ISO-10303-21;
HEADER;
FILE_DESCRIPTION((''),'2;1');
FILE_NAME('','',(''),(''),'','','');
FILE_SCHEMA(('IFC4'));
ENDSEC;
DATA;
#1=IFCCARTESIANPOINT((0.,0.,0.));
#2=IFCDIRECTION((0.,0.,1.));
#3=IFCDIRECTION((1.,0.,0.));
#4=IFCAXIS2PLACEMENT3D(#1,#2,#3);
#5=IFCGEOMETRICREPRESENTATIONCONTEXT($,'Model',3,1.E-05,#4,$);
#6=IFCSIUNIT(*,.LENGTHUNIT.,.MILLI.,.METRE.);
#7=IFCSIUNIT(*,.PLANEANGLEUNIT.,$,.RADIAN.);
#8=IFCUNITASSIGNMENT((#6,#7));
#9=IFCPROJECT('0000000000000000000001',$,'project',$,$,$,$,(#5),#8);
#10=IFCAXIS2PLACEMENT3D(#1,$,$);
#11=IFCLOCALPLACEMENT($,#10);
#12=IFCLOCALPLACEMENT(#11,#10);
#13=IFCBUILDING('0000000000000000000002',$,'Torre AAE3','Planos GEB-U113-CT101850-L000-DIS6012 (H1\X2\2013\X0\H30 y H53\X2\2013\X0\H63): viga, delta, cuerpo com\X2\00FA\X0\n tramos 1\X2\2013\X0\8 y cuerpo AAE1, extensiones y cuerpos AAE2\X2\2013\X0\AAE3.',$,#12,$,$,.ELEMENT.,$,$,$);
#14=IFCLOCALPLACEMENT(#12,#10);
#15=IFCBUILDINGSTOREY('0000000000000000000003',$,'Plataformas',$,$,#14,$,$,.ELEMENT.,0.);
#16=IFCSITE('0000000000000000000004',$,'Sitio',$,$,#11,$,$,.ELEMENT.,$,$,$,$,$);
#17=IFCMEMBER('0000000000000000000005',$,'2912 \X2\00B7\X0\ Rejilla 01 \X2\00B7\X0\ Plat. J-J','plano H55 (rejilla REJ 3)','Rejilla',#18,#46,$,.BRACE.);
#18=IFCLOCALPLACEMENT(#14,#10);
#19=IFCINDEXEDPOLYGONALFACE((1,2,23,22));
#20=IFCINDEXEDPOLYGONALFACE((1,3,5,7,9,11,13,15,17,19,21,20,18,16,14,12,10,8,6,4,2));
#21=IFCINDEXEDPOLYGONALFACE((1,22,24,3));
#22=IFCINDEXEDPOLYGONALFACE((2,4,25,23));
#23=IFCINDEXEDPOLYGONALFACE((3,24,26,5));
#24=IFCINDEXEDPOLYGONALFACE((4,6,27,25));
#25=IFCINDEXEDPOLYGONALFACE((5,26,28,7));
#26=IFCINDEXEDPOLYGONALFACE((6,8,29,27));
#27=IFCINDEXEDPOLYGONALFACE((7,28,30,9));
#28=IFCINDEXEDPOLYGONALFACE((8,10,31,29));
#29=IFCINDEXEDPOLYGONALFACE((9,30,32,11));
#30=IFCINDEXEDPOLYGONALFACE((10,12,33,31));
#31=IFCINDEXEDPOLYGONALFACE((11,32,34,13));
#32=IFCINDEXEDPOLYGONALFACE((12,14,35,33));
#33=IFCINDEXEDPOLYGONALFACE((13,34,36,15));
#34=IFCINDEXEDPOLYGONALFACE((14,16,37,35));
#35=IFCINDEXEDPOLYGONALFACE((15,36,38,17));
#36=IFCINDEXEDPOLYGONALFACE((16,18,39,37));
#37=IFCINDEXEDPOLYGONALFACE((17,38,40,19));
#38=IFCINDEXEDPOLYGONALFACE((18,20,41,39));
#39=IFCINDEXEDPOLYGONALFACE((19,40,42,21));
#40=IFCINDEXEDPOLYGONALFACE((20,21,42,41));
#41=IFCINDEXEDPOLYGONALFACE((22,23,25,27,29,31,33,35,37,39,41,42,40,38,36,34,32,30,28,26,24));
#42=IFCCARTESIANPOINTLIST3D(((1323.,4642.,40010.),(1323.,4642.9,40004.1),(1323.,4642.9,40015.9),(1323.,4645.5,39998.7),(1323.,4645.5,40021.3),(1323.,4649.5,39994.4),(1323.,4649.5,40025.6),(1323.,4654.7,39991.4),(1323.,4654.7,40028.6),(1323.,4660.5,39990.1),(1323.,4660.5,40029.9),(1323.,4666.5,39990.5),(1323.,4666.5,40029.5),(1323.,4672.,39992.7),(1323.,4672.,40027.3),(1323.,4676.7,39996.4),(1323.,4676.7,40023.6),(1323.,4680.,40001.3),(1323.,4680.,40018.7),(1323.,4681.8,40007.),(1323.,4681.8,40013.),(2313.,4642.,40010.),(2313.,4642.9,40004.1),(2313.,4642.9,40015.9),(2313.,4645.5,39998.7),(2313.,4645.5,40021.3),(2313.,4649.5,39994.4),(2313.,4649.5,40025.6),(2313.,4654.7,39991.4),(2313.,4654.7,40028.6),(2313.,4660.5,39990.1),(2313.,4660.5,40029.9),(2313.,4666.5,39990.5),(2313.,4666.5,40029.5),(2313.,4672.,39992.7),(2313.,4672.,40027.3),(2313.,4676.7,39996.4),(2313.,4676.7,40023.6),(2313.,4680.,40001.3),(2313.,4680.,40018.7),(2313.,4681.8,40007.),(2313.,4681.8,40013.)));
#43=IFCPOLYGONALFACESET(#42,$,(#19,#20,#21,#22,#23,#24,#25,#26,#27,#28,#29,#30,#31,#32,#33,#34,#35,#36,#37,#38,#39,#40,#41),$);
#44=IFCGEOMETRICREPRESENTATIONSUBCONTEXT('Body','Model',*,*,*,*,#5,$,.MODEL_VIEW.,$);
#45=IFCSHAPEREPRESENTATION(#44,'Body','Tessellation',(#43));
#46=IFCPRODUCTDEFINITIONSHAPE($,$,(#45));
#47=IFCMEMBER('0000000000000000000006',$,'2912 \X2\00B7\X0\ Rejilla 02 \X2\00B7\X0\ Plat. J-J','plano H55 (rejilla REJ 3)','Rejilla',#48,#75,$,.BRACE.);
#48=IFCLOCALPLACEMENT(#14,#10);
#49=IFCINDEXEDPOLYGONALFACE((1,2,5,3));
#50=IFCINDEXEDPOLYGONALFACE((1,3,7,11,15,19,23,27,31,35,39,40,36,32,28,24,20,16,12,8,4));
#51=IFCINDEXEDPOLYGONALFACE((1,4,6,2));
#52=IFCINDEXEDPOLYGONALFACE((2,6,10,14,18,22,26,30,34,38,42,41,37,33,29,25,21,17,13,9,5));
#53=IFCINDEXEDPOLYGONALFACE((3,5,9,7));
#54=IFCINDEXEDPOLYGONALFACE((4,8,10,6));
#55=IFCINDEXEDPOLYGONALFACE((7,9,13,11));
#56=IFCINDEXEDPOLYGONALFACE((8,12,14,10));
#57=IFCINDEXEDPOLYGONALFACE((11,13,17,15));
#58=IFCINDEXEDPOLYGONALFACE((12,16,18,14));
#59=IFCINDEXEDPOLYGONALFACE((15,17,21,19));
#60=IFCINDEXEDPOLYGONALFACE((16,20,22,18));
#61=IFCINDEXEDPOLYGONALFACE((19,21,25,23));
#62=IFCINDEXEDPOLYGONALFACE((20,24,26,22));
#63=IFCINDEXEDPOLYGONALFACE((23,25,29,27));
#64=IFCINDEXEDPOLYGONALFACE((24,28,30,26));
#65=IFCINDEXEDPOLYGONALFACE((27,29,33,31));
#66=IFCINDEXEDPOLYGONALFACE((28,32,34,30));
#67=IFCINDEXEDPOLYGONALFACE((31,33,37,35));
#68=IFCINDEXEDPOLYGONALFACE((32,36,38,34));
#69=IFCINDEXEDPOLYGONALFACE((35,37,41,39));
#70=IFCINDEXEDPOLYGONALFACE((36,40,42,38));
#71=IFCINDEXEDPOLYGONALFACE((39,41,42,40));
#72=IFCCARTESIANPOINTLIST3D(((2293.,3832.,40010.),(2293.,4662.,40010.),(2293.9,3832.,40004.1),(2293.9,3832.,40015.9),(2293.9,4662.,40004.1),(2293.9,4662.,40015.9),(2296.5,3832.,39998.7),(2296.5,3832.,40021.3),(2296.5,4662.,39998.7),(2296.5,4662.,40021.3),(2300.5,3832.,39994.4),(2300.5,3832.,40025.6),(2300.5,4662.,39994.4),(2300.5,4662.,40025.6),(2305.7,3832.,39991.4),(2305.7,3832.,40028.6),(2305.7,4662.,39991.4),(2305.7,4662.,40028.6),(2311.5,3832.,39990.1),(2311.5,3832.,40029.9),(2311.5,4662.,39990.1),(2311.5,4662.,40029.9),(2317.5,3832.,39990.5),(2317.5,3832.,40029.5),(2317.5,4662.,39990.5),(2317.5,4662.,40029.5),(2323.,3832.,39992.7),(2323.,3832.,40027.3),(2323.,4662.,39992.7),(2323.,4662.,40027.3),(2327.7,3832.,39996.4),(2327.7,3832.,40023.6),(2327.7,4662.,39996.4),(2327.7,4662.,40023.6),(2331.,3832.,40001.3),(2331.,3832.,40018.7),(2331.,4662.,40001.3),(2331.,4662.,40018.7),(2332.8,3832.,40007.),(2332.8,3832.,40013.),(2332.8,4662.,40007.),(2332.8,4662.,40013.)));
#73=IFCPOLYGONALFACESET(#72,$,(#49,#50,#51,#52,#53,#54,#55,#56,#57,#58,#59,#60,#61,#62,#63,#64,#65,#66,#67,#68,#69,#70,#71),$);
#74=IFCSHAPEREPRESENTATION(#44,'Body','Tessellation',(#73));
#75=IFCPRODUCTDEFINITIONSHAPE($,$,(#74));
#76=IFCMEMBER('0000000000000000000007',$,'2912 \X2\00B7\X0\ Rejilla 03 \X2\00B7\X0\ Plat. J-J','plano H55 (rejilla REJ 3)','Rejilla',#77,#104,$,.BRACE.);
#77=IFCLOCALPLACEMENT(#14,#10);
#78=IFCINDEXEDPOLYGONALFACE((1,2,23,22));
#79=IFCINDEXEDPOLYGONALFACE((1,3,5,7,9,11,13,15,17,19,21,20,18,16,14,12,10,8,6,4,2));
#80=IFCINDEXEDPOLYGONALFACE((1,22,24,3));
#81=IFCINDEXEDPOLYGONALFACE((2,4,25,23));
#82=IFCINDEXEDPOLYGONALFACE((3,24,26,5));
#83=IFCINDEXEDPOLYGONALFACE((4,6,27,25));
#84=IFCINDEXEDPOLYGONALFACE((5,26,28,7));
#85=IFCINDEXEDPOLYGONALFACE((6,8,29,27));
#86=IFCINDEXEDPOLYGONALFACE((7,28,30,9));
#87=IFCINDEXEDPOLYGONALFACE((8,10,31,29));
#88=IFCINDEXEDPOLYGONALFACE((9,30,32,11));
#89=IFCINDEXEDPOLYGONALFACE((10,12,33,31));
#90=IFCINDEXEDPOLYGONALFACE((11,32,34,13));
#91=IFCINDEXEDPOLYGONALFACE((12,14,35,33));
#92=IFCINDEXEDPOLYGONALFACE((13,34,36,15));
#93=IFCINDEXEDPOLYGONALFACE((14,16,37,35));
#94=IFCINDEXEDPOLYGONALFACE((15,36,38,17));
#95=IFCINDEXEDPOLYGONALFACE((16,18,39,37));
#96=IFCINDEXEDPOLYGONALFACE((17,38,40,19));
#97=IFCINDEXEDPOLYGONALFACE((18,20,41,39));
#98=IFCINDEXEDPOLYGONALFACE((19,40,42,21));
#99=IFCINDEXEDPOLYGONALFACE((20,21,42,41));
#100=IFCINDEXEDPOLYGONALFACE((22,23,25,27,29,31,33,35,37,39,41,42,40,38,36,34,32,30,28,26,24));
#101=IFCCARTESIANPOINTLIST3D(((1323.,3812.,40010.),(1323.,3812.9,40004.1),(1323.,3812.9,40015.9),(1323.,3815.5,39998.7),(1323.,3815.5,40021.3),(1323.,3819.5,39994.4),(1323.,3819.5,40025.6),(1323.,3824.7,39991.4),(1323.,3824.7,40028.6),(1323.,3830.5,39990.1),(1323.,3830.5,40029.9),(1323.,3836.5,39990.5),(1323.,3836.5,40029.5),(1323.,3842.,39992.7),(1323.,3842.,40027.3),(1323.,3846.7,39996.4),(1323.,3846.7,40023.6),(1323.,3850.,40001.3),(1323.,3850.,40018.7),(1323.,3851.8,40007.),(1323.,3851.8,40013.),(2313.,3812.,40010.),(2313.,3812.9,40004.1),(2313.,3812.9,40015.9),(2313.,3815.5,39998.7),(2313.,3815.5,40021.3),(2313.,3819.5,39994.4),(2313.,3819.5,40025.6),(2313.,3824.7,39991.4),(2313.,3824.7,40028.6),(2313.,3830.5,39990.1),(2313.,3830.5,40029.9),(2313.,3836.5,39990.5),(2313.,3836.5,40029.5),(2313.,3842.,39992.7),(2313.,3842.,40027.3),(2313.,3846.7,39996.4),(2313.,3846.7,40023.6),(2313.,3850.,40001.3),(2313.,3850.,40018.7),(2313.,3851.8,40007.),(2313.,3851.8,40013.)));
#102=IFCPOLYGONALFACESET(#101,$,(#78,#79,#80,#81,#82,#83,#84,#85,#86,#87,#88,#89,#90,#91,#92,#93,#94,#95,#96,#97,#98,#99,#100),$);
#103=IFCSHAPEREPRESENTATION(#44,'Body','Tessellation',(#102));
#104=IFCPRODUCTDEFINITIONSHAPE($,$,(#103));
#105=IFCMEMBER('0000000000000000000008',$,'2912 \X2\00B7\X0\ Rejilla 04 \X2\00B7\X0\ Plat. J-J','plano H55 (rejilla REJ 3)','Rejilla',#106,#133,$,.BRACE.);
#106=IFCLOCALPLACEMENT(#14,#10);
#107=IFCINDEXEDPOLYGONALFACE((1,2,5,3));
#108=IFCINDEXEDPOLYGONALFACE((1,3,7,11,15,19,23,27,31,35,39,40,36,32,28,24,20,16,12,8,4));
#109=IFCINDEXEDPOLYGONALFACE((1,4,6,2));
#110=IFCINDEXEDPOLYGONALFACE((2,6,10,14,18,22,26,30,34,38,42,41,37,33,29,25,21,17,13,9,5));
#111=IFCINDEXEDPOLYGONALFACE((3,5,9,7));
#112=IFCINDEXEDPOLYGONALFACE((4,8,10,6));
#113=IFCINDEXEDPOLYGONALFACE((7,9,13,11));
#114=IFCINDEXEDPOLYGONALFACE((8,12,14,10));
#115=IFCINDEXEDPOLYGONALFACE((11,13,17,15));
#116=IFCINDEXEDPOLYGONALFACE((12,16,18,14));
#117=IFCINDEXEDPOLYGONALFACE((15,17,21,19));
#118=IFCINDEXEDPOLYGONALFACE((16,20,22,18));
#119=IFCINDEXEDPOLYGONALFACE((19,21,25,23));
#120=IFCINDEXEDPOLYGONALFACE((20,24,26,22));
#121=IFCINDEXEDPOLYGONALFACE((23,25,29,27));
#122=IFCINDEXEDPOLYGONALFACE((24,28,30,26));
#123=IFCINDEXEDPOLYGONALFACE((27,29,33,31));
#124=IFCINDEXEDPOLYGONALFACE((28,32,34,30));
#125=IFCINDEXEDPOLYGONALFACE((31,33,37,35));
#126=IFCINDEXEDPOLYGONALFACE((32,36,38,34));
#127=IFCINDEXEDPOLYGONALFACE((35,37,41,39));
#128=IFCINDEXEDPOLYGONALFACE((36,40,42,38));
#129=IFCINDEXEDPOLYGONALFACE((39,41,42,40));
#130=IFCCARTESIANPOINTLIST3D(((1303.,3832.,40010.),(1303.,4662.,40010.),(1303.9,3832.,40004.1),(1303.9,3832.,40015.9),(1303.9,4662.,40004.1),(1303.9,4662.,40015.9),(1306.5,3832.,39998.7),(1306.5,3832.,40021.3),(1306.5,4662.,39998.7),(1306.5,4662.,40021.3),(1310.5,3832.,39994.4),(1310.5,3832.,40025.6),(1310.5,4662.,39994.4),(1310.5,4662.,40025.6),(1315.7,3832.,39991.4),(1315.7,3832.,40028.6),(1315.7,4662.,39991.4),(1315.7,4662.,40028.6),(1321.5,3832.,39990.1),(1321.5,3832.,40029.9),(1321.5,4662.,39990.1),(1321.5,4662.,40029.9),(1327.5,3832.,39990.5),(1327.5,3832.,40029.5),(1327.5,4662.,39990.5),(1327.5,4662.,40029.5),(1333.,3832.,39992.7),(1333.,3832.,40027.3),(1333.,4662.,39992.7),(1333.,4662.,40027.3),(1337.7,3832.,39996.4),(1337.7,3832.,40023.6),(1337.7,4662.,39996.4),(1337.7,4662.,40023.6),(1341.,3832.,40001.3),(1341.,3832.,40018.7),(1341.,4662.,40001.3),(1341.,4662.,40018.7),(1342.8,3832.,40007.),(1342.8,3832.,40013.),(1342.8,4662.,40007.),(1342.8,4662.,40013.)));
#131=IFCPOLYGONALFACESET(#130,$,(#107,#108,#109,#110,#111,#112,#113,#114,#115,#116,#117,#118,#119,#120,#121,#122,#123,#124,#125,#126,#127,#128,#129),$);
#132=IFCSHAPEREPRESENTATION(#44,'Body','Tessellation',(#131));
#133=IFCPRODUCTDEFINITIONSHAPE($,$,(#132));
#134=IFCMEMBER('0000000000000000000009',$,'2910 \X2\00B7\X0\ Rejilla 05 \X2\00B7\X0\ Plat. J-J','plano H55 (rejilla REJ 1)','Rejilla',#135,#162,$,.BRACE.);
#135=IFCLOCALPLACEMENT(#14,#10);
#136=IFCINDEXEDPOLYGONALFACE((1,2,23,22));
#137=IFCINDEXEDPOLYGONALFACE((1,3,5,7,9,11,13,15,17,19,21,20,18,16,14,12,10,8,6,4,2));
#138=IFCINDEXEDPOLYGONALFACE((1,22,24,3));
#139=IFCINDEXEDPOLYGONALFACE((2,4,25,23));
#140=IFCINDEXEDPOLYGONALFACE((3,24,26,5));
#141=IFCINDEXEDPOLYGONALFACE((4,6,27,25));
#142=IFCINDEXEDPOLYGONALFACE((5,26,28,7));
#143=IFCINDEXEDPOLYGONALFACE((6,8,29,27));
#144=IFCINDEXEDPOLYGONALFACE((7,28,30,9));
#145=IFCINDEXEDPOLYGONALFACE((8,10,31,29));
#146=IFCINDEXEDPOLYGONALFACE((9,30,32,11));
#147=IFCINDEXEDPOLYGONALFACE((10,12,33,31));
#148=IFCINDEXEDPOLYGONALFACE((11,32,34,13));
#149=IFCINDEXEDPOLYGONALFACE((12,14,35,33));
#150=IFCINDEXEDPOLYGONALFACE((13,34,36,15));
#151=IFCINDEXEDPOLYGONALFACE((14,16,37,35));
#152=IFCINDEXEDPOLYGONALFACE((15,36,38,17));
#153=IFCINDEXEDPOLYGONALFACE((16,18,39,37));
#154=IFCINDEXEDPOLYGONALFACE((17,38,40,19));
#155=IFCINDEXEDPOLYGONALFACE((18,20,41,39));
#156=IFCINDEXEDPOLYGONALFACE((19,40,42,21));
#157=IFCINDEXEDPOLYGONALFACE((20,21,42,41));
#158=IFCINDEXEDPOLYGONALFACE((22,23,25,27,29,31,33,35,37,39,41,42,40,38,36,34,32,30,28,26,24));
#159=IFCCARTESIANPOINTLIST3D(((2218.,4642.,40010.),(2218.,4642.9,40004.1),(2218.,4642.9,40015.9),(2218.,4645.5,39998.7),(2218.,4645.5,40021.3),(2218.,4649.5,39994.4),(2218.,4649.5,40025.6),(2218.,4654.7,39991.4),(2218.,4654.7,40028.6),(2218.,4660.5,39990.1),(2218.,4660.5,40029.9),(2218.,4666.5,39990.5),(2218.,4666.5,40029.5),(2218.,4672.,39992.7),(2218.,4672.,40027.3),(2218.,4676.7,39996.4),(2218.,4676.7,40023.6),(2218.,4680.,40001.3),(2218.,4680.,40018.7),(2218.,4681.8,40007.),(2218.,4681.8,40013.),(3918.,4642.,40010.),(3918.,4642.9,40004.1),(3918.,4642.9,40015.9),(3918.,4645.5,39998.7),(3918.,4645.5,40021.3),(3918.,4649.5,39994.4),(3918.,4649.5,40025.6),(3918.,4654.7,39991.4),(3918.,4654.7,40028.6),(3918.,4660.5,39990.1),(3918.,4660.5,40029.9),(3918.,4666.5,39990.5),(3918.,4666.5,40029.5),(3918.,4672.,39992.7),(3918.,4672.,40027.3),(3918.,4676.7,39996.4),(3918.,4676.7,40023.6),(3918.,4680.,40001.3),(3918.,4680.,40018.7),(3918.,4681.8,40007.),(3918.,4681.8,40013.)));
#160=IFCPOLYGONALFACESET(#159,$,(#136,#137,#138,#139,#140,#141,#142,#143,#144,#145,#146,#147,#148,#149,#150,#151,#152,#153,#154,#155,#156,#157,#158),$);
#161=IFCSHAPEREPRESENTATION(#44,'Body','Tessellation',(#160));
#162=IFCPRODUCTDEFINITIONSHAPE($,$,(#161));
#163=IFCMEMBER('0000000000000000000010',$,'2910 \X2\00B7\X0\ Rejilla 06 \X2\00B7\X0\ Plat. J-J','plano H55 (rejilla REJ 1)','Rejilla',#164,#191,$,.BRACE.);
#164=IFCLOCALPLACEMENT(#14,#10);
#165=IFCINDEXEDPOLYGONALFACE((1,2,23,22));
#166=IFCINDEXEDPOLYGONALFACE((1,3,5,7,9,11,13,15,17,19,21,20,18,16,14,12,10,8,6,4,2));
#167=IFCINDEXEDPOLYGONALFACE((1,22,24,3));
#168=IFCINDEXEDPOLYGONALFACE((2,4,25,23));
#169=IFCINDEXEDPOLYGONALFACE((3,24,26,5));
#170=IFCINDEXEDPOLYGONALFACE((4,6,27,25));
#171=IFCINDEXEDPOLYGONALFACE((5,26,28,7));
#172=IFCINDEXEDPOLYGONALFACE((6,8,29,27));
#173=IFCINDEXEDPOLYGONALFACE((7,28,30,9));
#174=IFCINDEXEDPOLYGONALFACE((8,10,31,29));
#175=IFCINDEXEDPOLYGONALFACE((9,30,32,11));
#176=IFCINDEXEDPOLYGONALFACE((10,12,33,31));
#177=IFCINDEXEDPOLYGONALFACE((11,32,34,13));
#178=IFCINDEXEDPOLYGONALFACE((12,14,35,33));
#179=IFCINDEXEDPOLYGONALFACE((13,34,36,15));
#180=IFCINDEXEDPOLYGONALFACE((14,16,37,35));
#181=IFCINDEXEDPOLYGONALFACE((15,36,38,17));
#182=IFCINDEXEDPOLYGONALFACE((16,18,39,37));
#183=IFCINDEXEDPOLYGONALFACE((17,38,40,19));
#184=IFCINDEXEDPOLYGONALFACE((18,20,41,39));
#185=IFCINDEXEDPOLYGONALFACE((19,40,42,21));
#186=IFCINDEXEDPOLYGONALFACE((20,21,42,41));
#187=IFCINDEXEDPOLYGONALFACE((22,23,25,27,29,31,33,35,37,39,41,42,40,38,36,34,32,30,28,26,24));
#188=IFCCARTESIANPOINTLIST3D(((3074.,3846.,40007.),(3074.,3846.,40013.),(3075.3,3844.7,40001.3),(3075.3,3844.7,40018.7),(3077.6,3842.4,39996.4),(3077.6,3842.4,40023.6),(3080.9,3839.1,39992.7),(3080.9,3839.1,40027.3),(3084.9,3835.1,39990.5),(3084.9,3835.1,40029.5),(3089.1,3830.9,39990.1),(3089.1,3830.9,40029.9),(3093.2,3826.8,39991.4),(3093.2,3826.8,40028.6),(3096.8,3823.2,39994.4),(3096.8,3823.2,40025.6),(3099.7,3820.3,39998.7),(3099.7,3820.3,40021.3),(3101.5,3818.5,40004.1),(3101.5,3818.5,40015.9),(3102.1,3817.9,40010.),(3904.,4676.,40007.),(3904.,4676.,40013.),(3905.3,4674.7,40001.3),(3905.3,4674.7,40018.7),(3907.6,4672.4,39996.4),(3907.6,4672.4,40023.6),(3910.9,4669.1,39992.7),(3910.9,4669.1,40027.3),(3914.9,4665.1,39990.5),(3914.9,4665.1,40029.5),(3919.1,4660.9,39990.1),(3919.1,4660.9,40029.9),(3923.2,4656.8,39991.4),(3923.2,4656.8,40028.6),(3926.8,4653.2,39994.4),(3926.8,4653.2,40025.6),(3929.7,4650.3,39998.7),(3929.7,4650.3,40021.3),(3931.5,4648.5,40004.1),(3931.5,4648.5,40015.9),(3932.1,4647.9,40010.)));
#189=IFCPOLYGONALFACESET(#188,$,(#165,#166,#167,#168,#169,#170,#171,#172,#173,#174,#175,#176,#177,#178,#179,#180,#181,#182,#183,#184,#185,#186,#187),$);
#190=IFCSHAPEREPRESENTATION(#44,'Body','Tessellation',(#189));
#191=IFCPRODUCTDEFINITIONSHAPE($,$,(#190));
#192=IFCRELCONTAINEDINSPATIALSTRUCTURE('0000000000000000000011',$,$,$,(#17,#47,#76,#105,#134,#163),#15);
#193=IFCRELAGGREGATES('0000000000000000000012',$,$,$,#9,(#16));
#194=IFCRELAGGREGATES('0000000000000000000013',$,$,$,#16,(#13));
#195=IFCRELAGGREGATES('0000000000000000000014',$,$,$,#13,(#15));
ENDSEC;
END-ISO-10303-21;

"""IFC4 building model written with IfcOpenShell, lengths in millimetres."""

from ifc_helpers import new_model, si_unit, frame, origin, origin_with_axes, place, context, subcontext, project, spatial, circle, extrude, element, save


model = new_model("IFC4")

# Units and contexts
model_context = context("Model", 3, precision=1e-05, world=origin_with_axes())
body_context = subcontext(model_context, "Body", "Model", "MODEL_VIEW")
ifc_project = project(units=[si_unit("LENGTHUNIT", "METRE", prefix="MILLI"), si_unit("PLANEANGLEUNIT", "RADIAN")], contexts=[model_context])

# Site, building, storey
site_placement = place(None, origin())
site = spatial("IfcSite", under=ifc_project, at=site_placement, Name="Sitio", CompositionType="ELEMENT")
building_placement = place(site_placement, origin())
building = spatial("IfcBuilding", under=site, at=building_placement, Name="Torre AAE3", Description="Planos GEB-U113-CT101850-L000-DIS6012 (H1–H30 y H53–H63): viga, delta, cuerpo común tramos 1–8 y cuerpo AAE1, extensiones y cuerpos AAE2–AAE3.", CompositionType="ELEMENT")
storey_placement = place(building_placement, origin())
storey = spatial("IfcBuildingStorey", under=building, at=storey_placement, Name="Plataformas", CompositionType="ELEMENT", Elevation=0.0)

# Members
member_1_placement = place(storey_placement, frame((1323.0, 4662.0, 40010.0), z_axis=(1.0, 0.0, 0.0), x_axis=(0.0, -1.0, 0.0)))
element("IfcMember", 1, at=member_1_placement, inside=storey, Name="2912 · Rejilla 01 · Plat. J-J", Description="plano H55 (rejilla REJ 3)", ObjectType="Rejilla", PredefinedType="BRACE", context=body_context, shape_type="SweptSolid", body=[
    extrude(circle(Radius=20.0), None, (0.0, 0.0, 1.0), 990.0),
])
member_2_placement = place(storey_placement, frame((2313.0, 4662.0, 40010.0), z_axis=(0.0, -1.0, 0.0), x_axis=(-1.0, 0.0, 0.0)))
element("IfcMember", 2, at=member_2_placement, inside=storey, Name="2912 · Rejilla 02 · Plat. J-J", Description="plano H55 (rejilla REJ 3)", ObjectType="Rejilla", PredefinedType="BRACE", context=body_context, shape_type="SweptSolid", body=[
    extrude(circle(Radius=20.0), None, (0.0, 0.0, 1.0), 830.0),
])
member_3_placement = place(storey_placement, frame((2313.0, 3832.0, 40010.0), z_axis=(-1.0, 0.0, 0.0), x_axis=(0.0, -1.0, 0.0)))
element("IfcMember", 3, at=member_3_placement, inside=storey, Name="2912 · Rejilla 03 · Plat. J-J", Description="plano H55 (rejilla REJ 3)", ObjectType="Rejilla", PredefinedType="BRACE", context=body_context, shape_type="SweptSolid", body=[
    extrude(circle(Radius=20.0), None, (0.0, 0.0, 1.0), 990.0),
])
member_4_placement = place(storey_placement, frame((1323.0, 3832.0, 40010.0), z_axis=(0.0, 1.0, 0.0), x_axis=(-1.0, 0.0, 0.0)))
element("IfcMember", 4, at=member_4_placement, inside=storey, Name="2912 · Rejilla 04 · Plat. J-J", Description="plano H55 (rejilla REJ 3)", ObjectType="Rejilla", PredefinedType="BRACE", context=body_context, shape_type="SweptSolid", body=[
    extrude(circle(Radius=20.0), None, (0.0, 0.0, 1.0), 830.0),
])
member_5_placement = place(storey_placement, frame((2218.0, 4662.0, 40010.0), z_axis=(1.0, 0.0, 0.0), x_axis=(0.0, -1.0, 0.0)))
element("IfcMember", 5, at=member_5_placement, inside=storey, Name="2910 · Rejilla 05 · Plat. J-J", Description="plano H55 (rejilla REJ 1)", ObjectType="Rejilla", PredefinedType="BRACE", context=body_context, shape_type="SweptSolid", body=[
    extrude(circle(Radius=20.0), None, (0.0, 0.0, 1.0), 1700.0),
])
member_6_placement = place(storey_placement, frame((3918.0, 4662.0, 40010.0), z_axis=(-0.707107, -0.707107, 0.0), x_axis=(0.707107, -0.707107, 0.0)))
element("IfcMember", 6, at=member_6_placement, inside=storey, Name="2910 · Rejilla 06 · Plat. J-J", Description="plano H55 (rejilla REJ 1)", ObjectType="Rejilla", PredefinedType="BRACE", context=body_context, shape_type="SweptSolid", body=[
    extrude(circle(Radius=20.0), None, (0.0, 0.0, 1.0), 1173.8),
])

save(model, "model.ifc")
